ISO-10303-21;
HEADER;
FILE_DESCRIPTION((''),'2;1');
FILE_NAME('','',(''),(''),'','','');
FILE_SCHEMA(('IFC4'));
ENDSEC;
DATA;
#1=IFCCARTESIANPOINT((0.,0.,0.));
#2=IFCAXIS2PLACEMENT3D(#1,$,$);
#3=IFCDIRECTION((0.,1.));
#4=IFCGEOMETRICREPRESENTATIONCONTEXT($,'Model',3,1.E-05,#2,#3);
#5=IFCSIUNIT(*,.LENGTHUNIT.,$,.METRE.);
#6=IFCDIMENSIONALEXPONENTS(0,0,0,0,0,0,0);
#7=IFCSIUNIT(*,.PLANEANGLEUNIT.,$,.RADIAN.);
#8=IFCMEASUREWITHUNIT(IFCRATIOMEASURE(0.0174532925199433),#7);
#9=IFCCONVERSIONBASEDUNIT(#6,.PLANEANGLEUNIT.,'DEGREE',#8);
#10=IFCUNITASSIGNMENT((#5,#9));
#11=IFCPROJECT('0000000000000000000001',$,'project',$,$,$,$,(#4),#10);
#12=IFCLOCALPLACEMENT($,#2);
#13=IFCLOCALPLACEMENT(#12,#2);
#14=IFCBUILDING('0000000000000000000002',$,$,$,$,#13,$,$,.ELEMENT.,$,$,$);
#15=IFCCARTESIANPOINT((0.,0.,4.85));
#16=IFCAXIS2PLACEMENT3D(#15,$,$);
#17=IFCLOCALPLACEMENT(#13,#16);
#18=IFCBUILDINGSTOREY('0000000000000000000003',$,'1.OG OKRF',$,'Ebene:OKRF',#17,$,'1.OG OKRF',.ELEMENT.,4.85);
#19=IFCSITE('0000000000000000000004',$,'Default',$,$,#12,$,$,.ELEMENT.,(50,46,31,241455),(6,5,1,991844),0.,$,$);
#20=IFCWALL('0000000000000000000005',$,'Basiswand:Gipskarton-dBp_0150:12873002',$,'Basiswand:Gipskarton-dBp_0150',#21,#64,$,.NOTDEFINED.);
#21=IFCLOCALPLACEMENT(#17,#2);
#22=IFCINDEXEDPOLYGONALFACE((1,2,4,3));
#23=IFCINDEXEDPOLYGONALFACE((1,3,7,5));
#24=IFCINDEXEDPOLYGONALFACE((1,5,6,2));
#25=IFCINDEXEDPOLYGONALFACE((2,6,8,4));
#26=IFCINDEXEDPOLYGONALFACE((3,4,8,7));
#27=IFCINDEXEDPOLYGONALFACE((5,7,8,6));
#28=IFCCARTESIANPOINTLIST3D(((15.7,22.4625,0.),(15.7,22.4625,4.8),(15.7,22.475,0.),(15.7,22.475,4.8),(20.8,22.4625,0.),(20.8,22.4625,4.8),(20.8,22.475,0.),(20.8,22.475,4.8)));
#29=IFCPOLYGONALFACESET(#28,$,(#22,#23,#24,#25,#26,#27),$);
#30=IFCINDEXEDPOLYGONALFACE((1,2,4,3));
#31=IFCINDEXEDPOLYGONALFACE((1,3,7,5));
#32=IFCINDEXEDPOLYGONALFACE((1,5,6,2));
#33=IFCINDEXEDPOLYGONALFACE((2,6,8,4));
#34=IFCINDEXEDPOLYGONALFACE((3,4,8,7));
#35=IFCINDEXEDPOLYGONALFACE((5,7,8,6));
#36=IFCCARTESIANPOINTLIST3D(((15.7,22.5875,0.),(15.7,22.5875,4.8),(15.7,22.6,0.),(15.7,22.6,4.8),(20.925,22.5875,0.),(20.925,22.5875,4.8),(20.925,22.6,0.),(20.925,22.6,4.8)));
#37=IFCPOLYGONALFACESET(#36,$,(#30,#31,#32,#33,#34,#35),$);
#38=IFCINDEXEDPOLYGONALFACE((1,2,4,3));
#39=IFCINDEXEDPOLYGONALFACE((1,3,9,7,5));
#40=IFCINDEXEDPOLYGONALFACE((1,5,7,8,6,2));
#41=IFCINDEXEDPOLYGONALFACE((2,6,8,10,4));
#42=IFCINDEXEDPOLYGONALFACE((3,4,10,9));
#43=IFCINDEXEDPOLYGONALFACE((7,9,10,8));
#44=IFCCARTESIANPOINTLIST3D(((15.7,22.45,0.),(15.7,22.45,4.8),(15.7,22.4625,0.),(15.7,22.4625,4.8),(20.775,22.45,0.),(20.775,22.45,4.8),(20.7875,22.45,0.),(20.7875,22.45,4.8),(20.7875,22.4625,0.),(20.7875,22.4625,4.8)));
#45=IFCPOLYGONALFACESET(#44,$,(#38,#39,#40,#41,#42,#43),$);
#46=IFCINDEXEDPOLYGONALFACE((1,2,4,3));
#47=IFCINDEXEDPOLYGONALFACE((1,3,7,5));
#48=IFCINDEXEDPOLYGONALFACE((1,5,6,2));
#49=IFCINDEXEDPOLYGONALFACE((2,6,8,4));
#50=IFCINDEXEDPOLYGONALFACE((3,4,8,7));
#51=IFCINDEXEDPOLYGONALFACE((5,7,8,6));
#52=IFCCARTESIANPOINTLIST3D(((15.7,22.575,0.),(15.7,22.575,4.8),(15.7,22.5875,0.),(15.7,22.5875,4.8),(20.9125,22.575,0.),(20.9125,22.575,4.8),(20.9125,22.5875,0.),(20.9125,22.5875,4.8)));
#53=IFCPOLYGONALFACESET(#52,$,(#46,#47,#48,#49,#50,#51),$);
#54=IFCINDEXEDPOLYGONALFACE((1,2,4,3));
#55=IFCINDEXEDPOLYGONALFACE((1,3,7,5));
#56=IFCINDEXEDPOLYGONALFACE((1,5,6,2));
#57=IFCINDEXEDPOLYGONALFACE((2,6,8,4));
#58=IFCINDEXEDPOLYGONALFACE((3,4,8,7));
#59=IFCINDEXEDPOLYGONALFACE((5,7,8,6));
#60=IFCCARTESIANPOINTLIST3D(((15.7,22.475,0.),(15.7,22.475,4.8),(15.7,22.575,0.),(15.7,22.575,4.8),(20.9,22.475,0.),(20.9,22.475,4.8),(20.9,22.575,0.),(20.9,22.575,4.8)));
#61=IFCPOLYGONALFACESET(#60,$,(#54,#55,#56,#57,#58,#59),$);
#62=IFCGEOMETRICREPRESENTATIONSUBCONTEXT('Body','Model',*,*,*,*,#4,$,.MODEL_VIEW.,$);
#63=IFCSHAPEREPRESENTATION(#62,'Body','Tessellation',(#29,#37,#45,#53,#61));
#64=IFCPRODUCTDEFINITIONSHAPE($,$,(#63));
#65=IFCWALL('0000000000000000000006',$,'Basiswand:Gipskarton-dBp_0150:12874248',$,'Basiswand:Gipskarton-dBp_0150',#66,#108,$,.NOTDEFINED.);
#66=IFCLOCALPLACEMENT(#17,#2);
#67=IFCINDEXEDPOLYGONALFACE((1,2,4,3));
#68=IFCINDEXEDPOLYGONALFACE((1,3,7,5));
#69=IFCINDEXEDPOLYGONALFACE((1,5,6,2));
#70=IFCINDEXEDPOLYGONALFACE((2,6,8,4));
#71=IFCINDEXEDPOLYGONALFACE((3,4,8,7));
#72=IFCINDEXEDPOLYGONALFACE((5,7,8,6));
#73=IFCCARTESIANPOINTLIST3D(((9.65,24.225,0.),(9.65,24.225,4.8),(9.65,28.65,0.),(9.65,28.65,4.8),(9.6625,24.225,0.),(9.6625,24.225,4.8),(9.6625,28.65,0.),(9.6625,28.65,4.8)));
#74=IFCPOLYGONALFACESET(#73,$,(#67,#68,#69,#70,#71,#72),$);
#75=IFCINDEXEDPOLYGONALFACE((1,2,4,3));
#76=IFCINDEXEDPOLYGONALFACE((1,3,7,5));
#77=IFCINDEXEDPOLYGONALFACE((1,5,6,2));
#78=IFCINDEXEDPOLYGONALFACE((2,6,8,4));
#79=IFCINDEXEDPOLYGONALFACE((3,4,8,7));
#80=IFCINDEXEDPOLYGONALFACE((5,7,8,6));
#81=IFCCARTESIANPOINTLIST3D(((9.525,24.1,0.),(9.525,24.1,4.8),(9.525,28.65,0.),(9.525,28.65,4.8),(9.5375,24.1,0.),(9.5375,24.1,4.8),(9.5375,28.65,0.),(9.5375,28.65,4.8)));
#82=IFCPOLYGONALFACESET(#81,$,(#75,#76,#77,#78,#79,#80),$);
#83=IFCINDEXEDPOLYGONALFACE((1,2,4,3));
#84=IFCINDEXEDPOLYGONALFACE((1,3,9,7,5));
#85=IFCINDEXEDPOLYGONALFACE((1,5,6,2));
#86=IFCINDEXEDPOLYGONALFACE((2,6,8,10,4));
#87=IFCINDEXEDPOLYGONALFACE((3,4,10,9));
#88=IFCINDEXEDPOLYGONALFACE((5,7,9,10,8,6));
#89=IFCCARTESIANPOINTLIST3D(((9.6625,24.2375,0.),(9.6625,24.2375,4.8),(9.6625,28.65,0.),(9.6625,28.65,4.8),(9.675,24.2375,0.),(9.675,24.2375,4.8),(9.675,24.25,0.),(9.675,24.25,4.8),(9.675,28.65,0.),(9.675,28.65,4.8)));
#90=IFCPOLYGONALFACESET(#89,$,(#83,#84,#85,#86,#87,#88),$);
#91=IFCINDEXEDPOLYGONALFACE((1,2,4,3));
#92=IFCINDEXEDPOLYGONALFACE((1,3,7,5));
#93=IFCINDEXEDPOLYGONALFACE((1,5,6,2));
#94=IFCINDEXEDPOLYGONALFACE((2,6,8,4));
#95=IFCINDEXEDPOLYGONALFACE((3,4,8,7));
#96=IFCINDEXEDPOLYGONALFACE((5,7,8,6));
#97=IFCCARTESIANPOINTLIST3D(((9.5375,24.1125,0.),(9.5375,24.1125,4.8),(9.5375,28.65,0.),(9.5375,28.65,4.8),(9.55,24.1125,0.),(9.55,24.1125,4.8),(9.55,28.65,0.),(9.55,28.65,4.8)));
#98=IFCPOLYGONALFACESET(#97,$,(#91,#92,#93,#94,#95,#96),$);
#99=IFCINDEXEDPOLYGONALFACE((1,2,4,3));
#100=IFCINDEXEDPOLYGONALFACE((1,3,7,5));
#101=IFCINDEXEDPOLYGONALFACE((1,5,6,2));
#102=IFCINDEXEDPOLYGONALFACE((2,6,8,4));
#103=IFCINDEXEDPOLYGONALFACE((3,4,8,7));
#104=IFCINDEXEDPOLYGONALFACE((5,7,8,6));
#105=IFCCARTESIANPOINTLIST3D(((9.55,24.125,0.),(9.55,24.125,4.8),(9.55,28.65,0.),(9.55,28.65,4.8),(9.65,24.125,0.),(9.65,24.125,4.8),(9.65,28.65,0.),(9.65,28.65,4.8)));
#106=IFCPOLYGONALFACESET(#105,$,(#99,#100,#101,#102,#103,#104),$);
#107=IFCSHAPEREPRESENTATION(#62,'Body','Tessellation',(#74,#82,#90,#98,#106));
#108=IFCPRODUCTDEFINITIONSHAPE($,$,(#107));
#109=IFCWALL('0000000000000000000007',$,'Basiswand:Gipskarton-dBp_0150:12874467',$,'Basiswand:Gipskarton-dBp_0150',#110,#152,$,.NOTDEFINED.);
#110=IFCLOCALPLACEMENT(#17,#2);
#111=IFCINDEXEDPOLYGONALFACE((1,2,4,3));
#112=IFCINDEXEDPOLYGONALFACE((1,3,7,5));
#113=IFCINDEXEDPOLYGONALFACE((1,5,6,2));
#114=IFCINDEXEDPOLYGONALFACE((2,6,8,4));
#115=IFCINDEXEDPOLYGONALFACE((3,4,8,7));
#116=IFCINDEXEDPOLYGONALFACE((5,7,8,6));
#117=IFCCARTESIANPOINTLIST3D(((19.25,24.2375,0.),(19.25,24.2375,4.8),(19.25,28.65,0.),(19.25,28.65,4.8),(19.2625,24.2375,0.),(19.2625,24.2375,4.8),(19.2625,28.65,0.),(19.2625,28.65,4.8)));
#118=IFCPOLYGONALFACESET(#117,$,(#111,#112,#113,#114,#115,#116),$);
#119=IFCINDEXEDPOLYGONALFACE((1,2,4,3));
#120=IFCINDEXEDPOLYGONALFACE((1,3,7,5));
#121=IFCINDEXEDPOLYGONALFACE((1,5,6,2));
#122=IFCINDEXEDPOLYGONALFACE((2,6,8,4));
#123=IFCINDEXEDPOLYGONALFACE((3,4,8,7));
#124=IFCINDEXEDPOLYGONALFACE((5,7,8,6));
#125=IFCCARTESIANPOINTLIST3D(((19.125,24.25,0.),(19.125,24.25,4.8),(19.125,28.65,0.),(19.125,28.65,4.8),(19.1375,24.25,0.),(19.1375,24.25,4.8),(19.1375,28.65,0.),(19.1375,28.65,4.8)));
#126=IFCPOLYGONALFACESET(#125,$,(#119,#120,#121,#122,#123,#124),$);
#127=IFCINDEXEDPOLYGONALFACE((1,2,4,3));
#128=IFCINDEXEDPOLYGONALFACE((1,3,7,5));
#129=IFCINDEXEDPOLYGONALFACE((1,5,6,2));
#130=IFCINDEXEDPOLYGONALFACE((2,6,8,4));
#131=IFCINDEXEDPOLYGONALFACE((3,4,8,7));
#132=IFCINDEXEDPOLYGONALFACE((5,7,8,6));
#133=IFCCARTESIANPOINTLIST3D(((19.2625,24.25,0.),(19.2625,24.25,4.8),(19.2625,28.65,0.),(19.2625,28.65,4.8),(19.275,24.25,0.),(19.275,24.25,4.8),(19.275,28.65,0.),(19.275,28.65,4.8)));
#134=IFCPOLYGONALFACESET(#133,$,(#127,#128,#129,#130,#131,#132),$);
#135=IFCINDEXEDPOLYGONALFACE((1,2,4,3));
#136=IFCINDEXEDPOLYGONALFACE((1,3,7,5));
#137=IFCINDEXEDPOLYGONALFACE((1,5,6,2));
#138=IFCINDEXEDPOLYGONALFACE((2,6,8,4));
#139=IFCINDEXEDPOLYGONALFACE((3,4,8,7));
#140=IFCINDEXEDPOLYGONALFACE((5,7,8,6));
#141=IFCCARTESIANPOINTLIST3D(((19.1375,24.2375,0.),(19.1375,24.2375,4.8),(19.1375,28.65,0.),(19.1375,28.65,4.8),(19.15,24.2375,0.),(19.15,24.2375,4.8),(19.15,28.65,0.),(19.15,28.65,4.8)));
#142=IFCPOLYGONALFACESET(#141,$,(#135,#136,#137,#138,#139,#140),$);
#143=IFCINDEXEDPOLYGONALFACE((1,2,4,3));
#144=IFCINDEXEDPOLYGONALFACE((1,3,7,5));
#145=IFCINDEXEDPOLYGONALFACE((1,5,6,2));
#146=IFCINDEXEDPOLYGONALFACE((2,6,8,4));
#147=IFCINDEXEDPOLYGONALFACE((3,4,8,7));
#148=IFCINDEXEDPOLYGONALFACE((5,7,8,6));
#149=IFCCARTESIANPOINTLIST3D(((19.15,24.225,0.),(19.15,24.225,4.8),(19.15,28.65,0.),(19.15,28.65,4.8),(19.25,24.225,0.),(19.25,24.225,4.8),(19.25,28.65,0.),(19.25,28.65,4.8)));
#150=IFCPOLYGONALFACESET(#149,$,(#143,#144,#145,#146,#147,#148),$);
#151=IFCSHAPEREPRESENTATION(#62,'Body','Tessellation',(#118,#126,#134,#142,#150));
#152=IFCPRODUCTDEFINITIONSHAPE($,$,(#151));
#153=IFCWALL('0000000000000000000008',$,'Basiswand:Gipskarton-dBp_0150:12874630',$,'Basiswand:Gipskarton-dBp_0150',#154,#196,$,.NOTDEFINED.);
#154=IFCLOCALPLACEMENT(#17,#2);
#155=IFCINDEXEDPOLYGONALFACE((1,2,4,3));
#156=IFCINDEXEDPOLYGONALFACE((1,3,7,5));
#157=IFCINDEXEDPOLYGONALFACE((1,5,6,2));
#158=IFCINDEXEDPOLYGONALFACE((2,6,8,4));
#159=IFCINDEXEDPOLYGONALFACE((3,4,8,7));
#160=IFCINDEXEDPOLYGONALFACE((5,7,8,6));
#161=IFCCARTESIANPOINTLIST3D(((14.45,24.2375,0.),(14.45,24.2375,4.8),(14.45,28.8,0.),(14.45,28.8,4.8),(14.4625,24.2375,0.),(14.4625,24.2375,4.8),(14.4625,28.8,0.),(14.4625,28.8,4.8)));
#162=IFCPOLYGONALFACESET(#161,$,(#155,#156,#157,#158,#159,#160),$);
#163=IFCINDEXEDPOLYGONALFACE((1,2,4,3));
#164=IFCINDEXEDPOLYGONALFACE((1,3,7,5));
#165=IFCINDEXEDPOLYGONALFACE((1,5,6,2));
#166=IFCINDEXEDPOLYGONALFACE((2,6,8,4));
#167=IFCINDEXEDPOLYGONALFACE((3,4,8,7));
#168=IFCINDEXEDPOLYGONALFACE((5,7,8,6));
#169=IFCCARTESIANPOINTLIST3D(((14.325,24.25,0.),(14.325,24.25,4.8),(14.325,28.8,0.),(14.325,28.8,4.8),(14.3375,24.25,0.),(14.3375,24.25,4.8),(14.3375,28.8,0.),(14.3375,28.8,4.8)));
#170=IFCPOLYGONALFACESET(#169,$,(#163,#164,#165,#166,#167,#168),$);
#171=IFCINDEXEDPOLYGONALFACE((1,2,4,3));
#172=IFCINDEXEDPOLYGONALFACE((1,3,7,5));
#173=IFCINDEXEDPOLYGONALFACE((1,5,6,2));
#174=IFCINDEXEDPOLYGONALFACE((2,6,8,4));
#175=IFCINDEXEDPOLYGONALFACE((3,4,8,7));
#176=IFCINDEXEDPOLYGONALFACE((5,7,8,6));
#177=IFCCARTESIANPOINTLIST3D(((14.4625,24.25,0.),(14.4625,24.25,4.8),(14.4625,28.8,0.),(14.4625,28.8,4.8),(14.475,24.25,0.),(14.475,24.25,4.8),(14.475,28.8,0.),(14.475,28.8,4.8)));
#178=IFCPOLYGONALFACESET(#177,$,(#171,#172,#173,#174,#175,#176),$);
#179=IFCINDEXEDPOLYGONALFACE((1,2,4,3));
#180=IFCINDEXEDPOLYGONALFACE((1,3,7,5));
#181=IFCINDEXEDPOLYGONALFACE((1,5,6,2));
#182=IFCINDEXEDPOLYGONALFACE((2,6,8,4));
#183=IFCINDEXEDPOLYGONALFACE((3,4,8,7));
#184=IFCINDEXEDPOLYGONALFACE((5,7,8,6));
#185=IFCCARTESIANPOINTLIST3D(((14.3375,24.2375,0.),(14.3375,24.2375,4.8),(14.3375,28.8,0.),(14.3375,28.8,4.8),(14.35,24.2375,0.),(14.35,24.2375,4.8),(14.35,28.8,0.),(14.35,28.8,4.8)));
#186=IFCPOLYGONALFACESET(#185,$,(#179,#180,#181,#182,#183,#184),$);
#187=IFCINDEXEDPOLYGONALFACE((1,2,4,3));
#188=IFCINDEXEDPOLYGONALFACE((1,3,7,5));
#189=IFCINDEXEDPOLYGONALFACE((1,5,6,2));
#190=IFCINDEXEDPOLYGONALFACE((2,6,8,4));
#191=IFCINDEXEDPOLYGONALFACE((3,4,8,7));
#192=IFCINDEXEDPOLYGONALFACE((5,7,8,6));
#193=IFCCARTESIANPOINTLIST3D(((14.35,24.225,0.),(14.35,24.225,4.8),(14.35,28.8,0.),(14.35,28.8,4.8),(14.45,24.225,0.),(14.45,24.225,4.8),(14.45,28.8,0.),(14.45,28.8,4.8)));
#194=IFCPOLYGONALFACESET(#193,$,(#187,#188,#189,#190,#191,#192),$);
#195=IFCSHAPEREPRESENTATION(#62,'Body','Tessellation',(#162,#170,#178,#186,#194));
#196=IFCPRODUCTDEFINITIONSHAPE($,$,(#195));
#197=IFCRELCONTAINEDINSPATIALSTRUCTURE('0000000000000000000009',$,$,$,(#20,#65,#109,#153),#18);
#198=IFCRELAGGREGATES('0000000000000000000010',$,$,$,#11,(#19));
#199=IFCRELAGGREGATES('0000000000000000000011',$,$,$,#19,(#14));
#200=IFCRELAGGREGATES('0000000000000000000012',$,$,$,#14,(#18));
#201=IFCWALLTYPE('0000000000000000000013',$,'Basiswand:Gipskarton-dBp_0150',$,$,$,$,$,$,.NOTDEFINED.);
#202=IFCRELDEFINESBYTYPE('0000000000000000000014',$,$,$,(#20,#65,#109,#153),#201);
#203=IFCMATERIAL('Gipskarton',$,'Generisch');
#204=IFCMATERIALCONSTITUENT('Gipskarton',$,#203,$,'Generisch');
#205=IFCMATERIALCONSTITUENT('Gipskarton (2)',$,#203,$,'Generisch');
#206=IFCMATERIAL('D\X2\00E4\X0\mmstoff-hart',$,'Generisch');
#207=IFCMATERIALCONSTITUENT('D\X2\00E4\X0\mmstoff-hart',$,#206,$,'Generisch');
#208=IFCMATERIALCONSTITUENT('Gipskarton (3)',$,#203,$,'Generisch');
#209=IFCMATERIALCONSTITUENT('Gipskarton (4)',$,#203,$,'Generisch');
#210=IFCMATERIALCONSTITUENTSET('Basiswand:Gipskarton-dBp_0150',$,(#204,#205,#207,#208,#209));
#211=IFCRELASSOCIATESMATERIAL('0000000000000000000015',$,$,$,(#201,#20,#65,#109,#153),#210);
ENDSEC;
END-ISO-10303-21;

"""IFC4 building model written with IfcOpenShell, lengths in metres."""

from ifc_helpers import new_model, entity, si_unit, converted_unit, direction, frame, origin, place, context, subcontext, project, spatial, indexed_curve, outline, extrude, material, constituent, constituent_set, type_object, element, save


model = new_model("IFC4")

# Units and contexts
model_context = context("Model", 3, precision=1e-05, world=origin(), true_north=direction((0.0, 1.0)))
body_context = subcontext(model_context, "Body", "Model", "MODEL_VIEW")
ifc_project = project(units=[si_unit("LENGTHUNIT", "METRE"), converted_unit("PLANEANGLEUNIT", "DEGREE", entity("IfcRatioMeasure", 0.0174532925199433), si_unit("PLANEANGLEUNIT", "RADIAN"), dimensions=[0, 0, 0, 0, 0, 0, 0])], contexts=[model_context])

# Site, building, storey
site_placement = place(None, origin())
site = spatial("IfcSite", under=ifc_project, at=site_placement, Name="Default", CompositionType="ELEMENT", RefLatitude=(50, 46, 31, 241455), RefLongitude=(6, 5, 1, 991844), RefElevation=0.0)
building_placement = place(site_placement, origin())
building = spatial("IfcBuilding", under=site, at=building_placement, CompositionType="ELEMENT")
storey_placement = place(building_placement, frame((0.0, 0.0, 4.85)))
storey = spatial("IfcBuildingStorey", under=building, at=storey_placement, Name="1.OG OKRF", ObjectType="Ebene:OKRF", LongName="1.OG OKRF", CompositionType="ELEMENT", Elevation=4.85)

# Wall
ifc_material_1 = material(Name="Gipskarton", Category="Generisch")
ifc_constituent_1 = constituent(ifc_material_1, Name="Gipskarton", Category="Generisch")
ifc_constituent_2 = constituent(ifc_material_1, Name="Gipskarton (2)", Category="Generisch")
ifc_material_2 = material(Name="Dämmstoff-hart", Category="Generisch")
ifc_constituent_3 = constituent(ifc_material_2, Name="Dämmstoff-hart", Category="Generisch")
ifc_constituent_4 = constituent(ifc_material_1, Name="Gipskarton (3)", Category="Generisch")
ifc_constituent_5 = constituent(ifc_material_1, Name="Gipskarton (4)", Category="Generisch")
ifc_constituent_set_1 = constituent_set(constituents=[ifc_constituent_1, ifc_constituent_2, ifc_constituent_3, ifc_constituent_4, ifc_constituent_5], Name="Basiswand:Gipskarton-dBp_0150")
wall_type_1 = type_object("IfcWallType", Name="Basiswand:Gipskarton-dBp_0150", PredefinedType="NOTDEFINED", material=ifc_constituent_set_1)
wall_1_placement = place(storey_placement, frame((15.7, 22.525, 0.0)))
element("IfcWall", 1, at=wall_1_placement, inside=storey, type_object=wall_type_1, material=ifc_constituent_set_1, Name="Basiswand:Gipskarton-dBp_0150:12873002", ObjectType="Basiswand:Gipskarton-dBp_0150", PredefinedType="NOTDEFINED", context=body_context, shape_type="SweptSolid", body=[
    extrude(outline(indexed_curve([(-2.55, -0.0062), (2.55, -0.0062), (2.55, 0.0062), (-2.55, 0.0062), (-2.55, -0.0062)], self_intersect=False)), frame((2.55, -0.0563, 0.0)), (0.0, 0.0, 1.0), 4.8),
    extrude(outline(indexed_curve([(-0.0063, -2.6125), (0.0062, -2.6125), (0.0063, 2.6125), (-0.0062, 2.6125), (-0.0063, -2.6125)], self_intersect=False)), frame((2.6125, 0.0687, 0.0), z_axis=(0.0, 0.0, 1.0), x_axis=(0.0, -1.0, 0.0)), (0.0, 0.0, 1.0), 4.8),
    extrude(outline(indexed_curve([(2.025, -0.005), (2.0375, -0.005), (2.0375, 0.0075), (-3.05, 0.0075), (-3.05, -0.005), (2.025, -0.005)], self_intersect=False)), frame((3.05, -0.07, 0.0)), (0.0, 0.0, 1.0), 4.8),
    extrude(outline(indexed_curve([(-2.6063, -0.0062), (2.6063, -0.0062), (2.6063, 0.0062), (-2.6063, 0.0062), (-2.6063, -0.0062)], self_intersect=False)), frame((2.6063, 0.0563, 0.0)), (0.0, 0.0, 1.0), 4.8),
    extrude(outline(indexed_curve([(-2.6, -0.05), (2.6, -0.05), (2.6, 0.05), (-2.6, 0.05), (-2.6, -0.05)], self_intersect=False)), frame((2.6, 0.0, 0.0)), (0.0, 0.0, 1.0), 4.8),
])

# Walls
wall_2_placement = place(storey_placement, frame((9.6, 28.65, 0.0), z_axis=(0.0, 0.0, 1.0), x_axis=(0.0, -1.0, 0.0)))
element("IfcWall", 2, at=wall_2_placement, inside=storey, type_object=wall_type_1, material=ifc_constituent_set_1, Name="Basiswand:Gipskarton-dBp_0150:12874248", ObjectType="Basiswand:Gipskarton-dBp_0150", PredefinedType="NOTDEFINED", context=body_context, shape_type="SweptSolid", body=[
    extrude(outline(indexed_curve([(-2.2125, -0.0062), (2.2125, -0.0062), (2.2125, 0.0062), (-2.2125, 0.0062), (-2.2125, -0.0062)], self_intersect=False)), frame((2.2125, 0.0562, 0.0)), (0.0, 0.0, 1.0), 4.8),
    extrude(outline(indexed_curve([(-0.0062, -2.275), (0.0063, -2.275), (0.0062, 2.275), (-0.0063, 2.275), (-0.0062, -2.275)], self_intersect=False)), frame((2.275, -0.0688, 0.0), z_axis=(0.0, 0.0, 1.0), x_axis=(0.0, 1.0, 0.0)), (0.0, 0.0, 1.0), 4.8),
    extrude(outline(indexed_curve([(-1.755, -0.005), (2.645, -0.005), (2.645, 0.0075), (-1.7675, 0.0075), (-1.7675, -0.005), (-1.755, -0.005)], self_intersect=False)), frame((2.645, 0.07, 0.0), z_axis=(0.0, 0.0, 1.0), x_axis=(-1.0, 0.0, 0.0)), (0.0, 0.0, 1.0), 4.8),
    extrude(outline(indexed_curve([(-2.2687, -0.0062), (2.2687, -0.0062), (2.2687, 0.0062), (-2.2687, 0.0062), (-2.2687, -0.0062)], self_intersect=False)), frame((2.2687, -0.0563, 0.0)), (0.0, 0.0, 1.0), 4.8),
    extrude(outline(indexed_curve([(-2.2625, -0.05), (2.2625, -0.05), (2.2625, 0.05), (-2.2625, 0.05), (-2.2625, -0.05)], self_intersect=False)), frame((2.2625, 0.0, 0.0)), (0.0, 0.0, 1.0), 4.8),
])
wall_3_placement = place(storey_placement, frame((19.2, 28.65, 0.0), z_axis=(0.0, 0.0, 1.0), x_axis=(0.0, -1.0, 0.0)))
element("IfcWall", 3, at=wall_3_placement, inside=storey, type_object=wall_type_1, material=ifc_constituent_set_1, Name="Basiswand:Gipskarton-dBp_0150:12874467", ObjectType="Basiswand:Gipskarton-dBp_0150", PredefinedType="NOTDEFINED", context=body_context, shape_type="SweptSolid", body=[
    extrude(outline(indexed_curve([(-2.2062, -0.0063), (2.2062, -0.0063), (2.2062, 0.0062), (-2.2062, 0.0062), (-2.2062, -0.0063)], self_intersect=False)), frame((2.2062, 0.0563, 0.0)), (0.0, 0.0, 1.0), 4.8),
    extrude(outline(indexed_curve([(-0.0062, -2.2), (0.0063, -2.2), (0.0062, 2.2), (-0.0063, 2.2), (-0.0062, -2.2)], self_intersect=False)), frame((2.2, -0.0687, 0.0), z_axis=(0.0, 0.0, 1.0), x_axis=(0.0, 1.0, 0.0)), (0.0, 0.0, 1.0), 4.8),
    extrude(outline(indexed_curve([(-0.0062, -2.2), (0.0063, -2.2), (0.0062, 2.2), (-0.0063, 2.2), (-0.0062, -2.2)], self_intersect=False)), frame((2.2, 0.0688, 0.0), z_axis=(0.0, 0.0, 1.0), x_axis=(0.0, -1.0, 0.0)), (0.0, 0.0, 1.0), 4.8),
    extrude(outline(indexed_curve([(-2.2062, -0.0063), (2.2062, -0.0063), (2.2062, 0.0062), (-2.2062, 0.0062), (-2.2062, -0.0063)], self_intersect=False)), frame((2.2062, -0.0562, 0.0)), (0.0, 0.0, 1.0), 4.8),
    extrude(outline(indexed_curve([(-2.2125, -0.05), (2.2125, -0.05), (2.2125, 0.05), (-2.2125, 0.05), (-2.2125, -0.05)], self_intersect=False)), frame((2.2125, 0.0, 0.0)), (0.0, 0.0, 1.0), 4.8),
])
wall_4_placement = place(storey_placement, frame((14.4, 28.8, 0.0), z_axis=(0.0, 0.0, 1.0), x_axis=(0.0, -1.0, 0.0)))
element("IfcWall", 4, at=wall_4_placement, inside=storey, type_object=wall_type_1, material=ifc_constituent_set_1, Name="Basiswand:Gipskarton-dBp_0150:12874630", ObjectType="Basiswand:Gipskarton-dBp_0150", PredefinedType="NOTDEFINED", context=body_context, shape_type="SweptSolid", body=[
    extrude(outline(indexed_curve([(-2.2812, -0.0063), (2.2812, -0.0063), (2.2812, 0.0062), (-2.2812, 0.0062), (-2.2812, -0.0063)], self_intersect=False)), frame((2.2812, 0.0563, 0.0)), (0.0, 0.0, 1.0), 4.8),
    extrude(outline(indexed_curve([(-0.0062, -2.275), (0.0063, -2.275), (0.0062, 2.275), (-0.0063, 2.275), (-0.0062, -2.275)], self_intersect=False)), frame((2.275, -0.0687, 0.0), z_axis=(0.0, 0.0, 1.0), x_axis=(0.0, 1.0, 0.0)), (0.0, 0.0, 1.0), 4.8),
    extrude(outline(indexed_curve([(-0.0062, -2.275), (0.0063, -2.275), (0.0062, 2.275), (-0.0063, 2.275), (-0.0062, -2.275)], self_intersect=False)), frame((2.275, 0.0688, 0.0), z_axis=(0.0, 0.0, 1.0), x_axis=(0.0, -1.0, 0.0)), (0.0, 0.0, 1.0), 4.8),
    extrude(outline(indexed_curve([(-2.2812, -0.0063), (2.2812, -0.0063), (2.2812, 0.0062), (-2.2812, 0.0062), (-2.2812, -0.0063)], self_intersect=False)), frame((2.2812, -0.0562, 0.0)), (0.0, 0.0, 1.0), 4.8),
    extrude(outline(indexed_curve([(-2.2875, -0.05), (2.2875, -0.05), (2.2875, 0.05), (-2.2875, 0.05), (-2.2875, -0.05)], self_intersect=False)), frame((2.2875, 0.0, 0.0)), (0.0, 0.0, 1.0), 4.8),
])

save(model, "model.ifc")
